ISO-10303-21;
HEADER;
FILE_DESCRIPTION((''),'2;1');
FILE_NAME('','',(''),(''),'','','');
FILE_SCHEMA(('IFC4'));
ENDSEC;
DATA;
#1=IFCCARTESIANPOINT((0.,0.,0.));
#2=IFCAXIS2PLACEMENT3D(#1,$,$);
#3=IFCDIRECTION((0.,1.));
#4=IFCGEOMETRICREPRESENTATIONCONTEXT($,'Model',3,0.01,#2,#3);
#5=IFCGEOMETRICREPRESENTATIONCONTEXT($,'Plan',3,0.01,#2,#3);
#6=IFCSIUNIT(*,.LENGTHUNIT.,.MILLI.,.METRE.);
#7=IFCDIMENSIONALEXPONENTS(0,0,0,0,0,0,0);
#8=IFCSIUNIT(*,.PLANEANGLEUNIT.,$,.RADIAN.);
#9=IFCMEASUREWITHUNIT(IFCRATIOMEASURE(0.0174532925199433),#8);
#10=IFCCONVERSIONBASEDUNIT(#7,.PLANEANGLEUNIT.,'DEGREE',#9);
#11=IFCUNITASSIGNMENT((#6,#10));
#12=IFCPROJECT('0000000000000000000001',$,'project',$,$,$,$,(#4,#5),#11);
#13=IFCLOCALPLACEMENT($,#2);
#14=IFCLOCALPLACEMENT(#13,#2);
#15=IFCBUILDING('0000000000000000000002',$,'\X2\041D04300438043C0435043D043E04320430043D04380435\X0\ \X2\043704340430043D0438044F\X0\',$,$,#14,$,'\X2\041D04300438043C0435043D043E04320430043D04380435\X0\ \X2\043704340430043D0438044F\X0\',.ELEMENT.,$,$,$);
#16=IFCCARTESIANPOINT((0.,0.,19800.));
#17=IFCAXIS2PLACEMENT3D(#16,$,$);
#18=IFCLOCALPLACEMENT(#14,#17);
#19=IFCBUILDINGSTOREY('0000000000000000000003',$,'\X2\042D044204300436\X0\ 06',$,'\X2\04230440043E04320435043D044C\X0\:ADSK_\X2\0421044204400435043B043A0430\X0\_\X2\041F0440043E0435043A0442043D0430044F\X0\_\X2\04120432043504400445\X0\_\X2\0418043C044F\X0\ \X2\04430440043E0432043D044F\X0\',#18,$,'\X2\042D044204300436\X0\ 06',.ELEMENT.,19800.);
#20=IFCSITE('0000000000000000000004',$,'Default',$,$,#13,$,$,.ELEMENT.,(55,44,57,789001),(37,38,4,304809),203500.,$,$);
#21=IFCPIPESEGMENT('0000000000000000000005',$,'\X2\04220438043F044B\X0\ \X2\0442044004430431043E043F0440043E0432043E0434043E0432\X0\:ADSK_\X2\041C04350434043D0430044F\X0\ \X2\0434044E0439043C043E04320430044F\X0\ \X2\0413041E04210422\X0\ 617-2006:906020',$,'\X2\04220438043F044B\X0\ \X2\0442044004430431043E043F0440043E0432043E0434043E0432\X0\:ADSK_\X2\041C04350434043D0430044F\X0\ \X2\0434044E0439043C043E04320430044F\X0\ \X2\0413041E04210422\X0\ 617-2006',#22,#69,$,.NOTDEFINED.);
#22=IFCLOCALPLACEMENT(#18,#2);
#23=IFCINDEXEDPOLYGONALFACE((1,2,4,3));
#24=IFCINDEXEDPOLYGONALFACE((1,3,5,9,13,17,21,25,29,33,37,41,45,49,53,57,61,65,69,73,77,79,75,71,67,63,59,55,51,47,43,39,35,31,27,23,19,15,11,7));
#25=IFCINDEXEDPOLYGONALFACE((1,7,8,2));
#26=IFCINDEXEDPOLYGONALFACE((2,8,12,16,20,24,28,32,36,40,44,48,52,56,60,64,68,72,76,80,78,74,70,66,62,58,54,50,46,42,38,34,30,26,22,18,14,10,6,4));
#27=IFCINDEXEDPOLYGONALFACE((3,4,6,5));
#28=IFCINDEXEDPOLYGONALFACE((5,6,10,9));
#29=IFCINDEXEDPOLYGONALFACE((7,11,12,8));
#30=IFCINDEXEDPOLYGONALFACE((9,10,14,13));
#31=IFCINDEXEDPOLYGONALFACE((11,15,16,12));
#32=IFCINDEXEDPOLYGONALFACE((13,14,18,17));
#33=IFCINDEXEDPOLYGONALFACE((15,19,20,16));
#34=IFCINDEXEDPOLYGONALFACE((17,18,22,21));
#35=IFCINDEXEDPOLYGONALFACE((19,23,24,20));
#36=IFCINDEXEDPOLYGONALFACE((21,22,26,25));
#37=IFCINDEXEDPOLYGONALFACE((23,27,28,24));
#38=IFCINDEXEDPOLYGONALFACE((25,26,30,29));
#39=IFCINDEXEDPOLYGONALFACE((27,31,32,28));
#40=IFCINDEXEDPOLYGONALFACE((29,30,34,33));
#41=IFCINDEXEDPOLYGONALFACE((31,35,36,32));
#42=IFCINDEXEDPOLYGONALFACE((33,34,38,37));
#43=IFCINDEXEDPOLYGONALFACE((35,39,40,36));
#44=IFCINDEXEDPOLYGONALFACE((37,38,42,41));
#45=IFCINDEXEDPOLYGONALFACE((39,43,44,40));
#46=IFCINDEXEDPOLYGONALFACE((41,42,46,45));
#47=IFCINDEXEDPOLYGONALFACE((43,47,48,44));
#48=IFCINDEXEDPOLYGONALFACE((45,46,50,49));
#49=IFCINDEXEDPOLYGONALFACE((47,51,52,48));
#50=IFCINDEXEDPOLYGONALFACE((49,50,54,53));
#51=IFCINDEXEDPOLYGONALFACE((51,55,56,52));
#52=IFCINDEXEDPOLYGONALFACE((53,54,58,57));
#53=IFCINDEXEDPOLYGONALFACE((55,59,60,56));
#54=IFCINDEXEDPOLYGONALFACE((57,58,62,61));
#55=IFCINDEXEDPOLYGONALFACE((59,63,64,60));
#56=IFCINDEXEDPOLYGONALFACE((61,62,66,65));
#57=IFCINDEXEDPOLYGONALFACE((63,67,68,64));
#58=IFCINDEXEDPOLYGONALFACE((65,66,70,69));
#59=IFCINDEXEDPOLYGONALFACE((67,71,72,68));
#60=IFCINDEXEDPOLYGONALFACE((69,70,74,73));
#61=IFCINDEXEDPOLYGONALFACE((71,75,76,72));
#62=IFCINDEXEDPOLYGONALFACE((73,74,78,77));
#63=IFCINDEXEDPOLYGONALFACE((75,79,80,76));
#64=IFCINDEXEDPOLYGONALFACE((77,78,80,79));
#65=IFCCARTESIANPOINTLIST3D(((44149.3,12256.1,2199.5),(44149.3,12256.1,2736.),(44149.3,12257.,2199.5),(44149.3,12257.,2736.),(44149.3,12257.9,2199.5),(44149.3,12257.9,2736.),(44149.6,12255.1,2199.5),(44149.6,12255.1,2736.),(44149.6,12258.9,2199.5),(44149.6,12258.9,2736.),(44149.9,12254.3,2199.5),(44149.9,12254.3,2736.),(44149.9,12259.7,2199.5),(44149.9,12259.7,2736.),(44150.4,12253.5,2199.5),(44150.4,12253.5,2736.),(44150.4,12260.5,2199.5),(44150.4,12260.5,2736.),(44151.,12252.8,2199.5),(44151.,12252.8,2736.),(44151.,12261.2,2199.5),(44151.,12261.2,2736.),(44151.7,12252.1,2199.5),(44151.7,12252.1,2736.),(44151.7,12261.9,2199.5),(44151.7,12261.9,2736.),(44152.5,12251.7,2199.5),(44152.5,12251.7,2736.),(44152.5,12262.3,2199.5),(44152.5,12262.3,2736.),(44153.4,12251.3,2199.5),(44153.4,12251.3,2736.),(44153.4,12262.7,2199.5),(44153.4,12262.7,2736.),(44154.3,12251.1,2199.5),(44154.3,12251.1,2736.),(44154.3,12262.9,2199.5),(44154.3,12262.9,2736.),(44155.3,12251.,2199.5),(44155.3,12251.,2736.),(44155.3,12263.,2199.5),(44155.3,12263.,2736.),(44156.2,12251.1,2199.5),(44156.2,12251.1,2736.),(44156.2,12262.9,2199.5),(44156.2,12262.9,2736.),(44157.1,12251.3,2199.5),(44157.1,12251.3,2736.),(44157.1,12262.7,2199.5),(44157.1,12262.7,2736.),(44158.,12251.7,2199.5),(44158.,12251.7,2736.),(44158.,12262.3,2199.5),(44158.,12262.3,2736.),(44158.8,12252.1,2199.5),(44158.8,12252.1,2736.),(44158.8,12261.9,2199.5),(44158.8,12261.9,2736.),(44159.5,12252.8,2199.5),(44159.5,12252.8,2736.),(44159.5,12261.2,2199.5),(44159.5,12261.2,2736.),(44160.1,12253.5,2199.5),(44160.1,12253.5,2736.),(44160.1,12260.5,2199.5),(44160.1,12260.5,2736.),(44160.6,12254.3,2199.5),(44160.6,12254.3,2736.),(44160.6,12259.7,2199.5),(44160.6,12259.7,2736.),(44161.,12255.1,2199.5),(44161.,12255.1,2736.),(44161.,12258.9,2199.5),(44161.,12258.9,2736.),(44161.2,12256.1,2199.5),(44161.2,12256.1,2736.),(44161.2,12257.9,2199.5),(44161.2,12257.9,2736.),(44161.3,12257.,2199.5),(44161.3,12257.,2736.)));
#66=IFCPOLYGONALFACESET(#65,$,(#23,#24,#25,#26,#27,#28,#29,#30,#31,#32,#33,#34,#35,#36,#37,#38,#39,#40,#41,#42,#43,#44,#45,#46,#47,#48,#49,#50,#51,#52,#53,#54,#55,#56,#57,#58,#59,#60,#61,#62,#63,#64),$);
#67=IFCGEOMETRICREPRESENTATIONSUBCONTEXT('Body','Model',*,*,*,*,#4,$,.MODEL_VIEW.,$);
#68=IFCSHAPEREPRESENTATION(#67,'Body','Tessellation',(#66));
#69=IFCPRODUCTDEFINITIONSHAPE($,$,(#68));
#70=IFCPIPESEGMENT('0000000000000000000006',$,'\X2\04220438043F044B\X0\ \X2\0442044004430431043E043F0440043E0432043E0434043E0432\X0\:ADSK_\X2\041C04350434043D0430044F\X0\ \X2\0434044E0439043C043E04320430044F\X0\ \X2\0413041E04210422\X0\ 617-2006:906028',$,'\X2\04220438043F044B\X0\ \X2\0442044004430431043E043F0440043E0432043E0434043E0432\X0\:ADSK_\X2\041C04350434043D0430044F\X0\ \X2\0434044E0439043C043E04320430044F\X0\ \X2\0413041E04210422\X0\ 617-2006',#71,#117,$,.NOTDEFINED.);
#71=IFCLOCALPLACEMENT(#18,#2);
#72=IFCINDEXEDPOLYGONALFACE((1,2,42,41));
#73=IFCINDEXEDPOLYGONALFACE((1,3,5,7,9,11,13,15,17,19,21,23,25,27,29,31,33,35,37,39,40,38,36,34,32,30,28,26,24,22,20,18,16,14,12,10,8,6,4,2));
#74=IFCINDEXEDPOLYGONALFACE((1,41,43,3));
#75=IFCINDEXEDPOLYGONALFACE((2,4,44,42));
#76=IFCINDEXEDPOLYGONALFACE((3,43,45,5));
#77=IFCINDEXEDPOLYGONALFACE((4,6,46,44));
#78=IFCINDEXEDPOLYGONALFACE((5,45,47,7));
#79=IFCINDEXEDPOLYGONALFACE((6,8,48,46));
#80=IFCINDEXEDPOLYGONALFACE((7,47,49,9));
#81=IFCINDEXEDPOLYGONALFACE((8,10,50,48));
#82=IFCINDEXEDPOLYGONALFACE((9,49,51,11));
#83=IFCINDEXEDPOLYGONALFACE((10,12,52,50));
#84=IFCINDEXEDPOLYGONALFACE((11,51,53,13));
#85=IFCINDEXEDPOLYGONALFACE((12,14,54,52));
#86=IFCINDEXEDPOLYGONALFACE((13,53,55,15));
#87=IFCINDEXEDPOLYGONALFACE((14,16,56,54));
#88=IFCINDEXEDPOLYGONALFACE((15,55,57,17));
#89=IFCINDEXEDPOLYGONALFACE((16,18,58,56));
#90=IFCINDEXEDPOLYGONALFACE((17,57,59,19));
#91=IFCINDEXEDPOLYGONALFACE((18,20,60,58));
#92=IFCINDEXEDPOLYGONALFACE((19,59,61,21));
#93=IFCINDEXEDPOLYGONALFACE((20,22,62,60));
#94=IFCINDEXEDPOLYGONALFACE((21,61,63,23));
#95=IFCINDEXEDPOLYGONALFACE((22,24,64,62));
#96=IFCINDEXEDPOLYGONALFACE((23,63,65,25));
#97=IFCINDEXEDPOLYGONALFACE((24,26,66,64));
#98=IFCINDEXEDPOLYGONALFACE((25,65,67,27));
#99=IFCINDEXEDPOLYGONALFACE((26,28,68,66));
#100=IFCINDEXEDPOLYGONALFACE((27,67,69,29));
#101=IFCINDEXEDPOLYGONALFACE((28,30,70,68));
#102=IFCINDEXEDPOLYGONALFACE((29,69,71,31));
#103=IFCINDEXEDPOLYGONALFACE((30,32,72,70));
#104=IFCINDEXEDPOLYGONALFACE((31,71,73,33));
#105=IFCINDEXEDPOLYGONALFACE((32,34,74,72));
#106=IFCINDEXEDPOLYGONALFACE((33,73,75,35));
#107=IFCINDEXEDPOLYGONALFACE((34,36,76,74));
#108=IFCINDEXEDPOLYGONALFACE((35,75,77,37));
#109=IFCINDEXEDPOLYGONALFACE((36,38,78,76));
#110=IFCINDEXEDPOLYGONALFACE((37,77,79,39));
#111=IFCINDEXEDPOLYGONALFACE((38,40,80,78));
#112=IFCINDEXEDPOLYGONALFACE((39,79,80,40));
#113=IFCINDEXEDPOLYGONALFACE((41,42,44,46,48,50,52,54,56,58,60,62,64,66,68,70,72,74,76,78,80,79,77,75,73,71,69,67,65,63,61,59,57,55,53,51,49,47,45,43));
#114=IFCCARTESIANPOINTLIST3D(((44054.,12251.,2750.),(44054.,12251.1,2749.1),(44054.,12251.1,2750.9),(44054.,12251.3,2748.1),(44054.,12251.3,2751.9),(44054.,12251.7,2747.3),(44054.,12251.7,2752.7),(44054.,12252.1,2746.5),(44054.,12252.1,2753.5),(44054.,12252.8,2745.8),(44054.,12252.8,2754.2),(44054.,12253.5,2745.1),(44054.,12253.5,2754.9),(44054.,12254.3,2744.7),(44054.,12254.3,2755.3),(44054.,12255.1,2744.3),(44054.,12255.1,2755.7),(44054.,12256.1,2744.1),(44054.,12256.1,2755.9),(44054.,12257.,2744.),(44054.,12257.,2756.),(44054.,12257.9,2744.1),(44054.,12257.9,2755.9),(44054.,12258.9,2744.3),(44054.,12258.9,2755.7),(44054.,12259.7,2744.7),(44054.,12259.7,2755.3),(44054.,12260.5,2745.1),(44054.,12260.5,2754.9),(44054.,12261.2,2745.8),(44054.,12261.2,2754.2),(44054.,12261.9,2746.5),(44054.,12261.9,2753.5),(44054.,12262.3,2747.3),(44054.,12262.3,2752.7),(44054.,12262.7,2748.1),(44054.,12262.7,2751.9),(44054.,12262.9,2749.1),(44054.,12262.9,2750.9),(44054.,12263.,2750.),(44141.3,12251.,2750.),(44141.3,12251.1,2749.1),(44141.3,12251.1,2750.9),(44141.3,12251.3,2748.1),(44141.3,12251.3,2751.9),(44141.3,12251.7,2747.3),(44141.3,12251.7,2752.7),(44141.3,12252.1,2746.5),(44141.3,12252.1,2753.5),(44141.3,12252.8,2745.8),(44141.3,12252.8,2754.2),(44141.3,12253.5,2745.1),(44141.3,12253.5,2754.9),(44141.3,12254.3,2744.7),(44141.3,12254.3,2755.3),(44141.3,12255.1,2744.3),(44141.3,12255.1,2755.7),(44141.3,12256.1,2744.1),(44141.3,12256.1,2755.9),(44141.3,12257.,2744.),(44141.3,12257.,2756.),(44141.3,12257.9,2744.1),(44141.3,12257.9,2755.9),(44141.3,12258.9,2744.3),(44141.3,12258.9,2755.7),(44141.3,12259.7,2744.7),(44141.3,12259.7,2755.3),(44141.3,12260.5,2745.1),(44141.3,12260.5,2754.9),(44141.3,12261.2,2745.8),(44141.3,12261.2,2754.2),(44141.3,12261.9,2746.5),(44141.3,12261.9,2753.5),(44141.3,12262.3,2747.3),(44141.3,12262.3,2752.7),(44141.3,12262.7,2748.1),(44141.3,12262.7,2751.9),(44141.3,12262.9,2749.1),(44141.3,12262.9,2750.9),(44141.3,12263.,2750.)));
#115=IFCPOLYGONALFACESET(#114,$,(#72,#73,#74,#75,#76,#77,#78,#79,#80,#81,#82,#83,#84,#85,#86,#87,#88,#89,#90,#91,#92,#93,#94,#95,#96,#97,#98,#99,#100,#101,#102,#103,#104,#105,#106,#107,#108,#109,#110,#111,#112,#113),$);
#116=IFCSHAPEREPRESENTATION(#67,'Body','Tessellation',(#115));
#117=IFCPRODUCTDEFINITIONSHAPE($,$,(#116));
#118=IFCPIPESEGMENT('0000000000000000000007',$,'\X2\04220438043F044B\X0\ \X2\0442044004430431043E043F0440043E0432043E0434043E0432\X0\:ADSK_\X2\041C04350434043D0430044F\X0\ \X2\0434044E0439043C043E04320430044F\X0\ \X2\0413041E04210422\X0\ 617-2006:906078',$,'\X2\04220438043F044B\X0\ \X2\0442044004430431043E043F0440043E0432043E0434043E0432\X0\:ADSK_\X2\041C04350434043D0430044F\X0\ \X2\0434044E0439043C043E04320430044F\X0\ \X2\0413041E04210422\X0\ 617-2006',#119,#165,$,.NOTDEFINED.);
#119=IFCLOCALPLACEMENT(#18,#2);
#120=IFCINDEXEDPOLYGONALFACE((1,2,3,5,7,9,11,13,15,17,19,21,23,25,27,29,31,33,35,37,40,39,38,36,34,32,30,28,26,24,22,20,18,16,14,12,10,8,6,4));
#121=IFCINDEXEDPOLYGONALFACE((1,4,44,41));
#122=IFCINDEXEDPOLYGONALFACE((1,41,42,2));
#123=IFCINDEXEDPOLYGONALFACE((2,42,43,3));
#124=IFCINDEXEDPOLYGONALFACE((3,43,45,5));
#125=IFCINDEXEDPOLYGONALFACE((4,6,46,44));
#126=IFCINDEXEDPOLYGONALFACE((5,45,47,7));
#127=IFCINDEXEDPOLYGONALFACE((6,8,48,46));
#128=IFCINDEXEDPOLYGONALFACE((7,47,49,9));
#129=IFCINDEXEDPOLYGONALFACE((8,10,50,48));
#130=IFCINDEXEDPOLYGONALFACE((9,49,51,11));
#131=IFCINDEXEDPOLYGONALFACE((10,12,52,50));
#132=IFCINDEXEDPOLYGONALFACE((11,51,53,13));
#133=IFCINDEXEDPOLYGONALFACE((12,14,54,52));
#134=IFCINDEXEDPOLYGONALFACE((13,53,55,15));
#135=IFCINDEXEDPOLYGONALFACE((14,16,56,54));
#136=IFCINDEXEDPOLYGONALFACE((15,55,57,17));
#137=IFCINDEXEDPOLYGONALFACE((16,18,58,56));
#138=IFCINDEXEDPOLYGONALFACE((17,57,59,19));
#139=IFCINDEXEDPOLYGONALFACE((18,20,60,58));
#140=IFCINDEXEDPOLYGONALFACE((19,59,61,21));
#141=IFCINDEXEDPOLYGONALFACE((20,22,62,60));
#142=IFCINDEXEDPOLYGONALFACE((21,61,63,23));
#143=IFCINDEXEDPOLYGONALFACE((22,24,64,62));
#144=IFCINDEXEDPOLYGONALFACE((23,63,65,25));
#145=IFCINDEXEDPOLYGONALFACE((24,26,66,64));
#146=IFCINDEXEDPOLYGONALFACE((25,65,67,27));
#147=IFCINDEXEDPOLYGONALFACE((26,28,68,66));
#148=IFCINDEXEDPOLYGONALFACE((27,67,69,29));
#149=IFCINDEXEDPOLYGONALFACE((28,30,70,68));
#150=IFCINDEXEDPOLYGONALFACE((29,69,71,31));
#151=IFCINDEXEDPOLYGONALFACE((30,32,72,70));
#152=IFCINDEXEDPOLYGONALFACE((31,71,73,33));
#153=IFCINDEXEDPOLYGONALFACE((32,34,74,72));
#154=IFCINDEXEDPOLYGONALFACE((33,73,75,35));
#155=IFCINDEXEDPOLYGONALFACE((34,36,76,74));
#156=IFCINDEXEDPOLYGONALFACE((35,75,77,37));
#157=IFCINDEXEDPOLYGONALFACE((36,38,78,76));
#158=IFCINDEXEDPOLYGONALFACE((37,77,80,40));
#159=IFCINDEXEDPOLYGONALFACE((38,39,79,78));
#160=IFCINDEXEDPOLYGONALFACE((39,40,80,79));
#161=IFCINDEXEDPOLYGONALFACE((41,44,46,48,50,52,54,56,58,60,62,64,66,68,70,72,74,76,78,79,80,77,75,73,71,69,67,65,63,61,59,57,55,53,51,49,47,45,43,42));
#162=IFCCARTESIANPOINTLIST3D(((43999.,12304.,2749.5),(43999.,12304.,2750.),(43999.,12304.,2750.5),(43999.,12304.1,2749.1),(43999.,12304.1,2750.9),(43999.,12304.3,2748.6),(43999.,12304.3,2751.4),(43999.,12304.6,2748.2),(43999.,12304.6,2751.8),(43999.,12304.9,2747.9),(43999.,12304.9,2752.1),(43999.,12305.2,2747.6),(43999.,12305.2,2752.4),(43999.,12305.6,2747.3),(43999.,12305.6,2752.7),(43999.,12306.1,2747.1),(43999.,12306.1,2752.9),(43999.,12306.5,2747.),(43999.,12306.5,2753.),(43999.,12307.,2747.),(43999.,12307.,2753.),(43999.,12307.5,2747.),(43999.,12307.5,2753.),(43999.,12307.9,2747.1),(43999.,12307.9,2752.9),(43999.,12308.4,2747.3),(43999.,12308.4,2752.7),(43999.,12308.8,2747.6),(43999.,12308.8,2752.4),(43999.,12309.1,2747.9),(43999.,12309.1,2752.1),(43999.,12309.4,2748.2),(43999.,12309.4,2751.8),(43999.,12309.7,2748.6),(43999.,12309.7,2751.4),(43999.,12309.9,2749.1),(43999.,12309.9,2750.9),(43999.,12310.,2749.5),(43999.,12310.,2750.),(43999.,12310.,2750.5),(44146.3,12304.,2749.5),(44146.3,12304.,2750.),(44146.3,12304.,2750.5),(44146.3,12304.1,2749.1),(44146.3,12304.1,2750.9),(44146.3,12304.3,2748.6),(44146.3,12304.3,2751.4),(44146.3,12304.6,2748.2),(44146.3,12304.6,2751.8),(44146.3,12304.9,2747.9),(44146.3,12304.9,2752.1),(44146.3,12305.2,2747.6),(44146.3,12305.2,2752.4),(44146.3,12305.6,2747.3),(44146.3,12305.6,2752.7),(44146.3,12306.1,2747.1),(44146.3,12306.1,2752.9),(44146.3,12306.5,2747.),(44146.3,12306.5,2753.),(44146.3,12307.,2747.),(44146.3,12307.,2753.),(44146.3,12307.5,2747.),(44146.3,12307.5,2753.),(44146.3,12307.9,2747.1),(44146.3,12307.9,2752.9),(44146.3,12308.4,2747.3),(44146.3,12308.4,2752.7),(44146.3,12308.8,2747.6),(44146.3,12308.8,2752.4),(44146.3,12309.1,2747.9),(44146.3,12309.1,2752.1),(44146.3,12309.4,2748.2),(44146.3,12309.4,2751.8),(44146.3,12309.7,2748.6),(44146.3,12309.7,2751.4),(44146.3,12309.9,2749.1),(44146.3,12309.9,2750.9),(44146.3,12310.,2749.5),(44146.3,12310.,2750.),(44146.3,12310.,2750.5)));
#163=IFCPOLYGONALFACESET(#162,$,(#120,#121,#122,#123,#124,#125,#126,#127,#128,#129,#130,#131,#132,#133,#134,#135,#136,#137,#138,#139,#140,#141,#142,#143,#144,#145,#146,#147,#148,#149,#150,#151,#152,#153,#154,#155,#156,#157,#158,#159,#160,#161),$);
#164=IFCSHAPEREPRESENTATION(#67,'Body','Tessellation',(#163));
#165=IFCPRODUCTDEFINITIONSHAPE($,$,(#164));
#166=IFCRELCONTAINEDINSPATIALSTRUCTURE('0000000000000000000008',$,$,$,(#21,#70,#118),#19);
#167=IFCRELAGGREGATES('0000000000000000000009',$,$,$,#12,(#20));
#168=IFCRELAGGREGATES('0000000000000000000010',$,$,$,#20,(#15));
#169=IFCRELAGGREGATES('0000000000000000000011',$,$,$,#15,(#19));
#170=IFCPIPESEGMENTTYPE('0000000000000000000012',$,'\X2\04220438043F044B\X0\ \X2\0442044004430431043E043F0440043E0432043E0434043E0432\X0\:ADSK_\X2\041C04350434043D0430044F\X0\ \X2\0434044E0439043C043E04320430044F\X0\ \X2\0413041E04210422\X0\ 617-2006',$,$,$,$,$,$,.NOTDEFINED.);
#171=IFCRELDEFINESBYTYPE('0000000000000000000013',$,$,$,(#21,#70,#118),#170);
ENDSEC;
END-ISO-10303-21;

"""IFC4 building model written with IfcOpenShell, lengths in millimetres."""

from ifc_helpers import new_model, entity, si_unit, converted_unit, direction, frame, origin, place, context, subcontext, project, spatial, indexed_curve, outline, extrude, type_object, element, save


model = new_model("IFC4")

# Units and contexts
model_context = context("Model", 3, precision=0.01, world=origin(), true_north=direction((0.0, 1.0)))
plan_context = context("Plan", 3, precision=0.01, world=origin(), true_north=direction((0.0, 1.0)))
body_context = subcontext(model_context, "Body", "Model", "MODEL_VIEW")
ifc_project = project(units=[si_unit("LENGTHUNIT", "METRE", prefix="MILLI"), converted_unit("PLANEANGLEUNIT", "DEGREE", entity("IfcRatioMeasure", 0.0174532925199433), si_unit("PLANEANGLEUNIT", "RADIAN"), dimensions=[0, 0, 0, 0, 0, 0, 0])], contexts=[model_context, plan_context])

# Site, building, storey
site_placement = place(None, origin())
site = spatial("IfcSite", under=ifc_project, at=site_placement, Name="Default", CompositionType="ELEMENT", RefLatitude=(55, 44, 57, 789001), RefLongitude=(37, 38, 4, 304809), RefElevation=203500.0)
building_placement = place(site_placement, origin())
building = spatial("IfcBuilding", under=site, at=building_placement, Name="Наименование здания", LongName="Наименование здания", CompositionType="ELEMENT")
storey_placement = place(building_placement, frame((0.0, 0.0, 19800.0)))
storey = spatial("IfcBuildingStorey", under=building, at=storey_placement, Name="Этаж 06", ObjectType="Уровень:ADSK_Стрелка_Проектная_Вверх_Имя уровня", LongName="Этаж 06", CompositionType="ELEMENT", Elevation=19800.0)

# Pipe segments
pipe_segment_type = type_object("IfcPipeSegmentType", Name="Типы трубопроводов:ADSK_Медная дюймовая ГОСТ 617-2006", PredefinedType="NOTDEFINED")
placement = place(storey_placement, origin())
element("IfcPipeSegment", 1, at=placement, inside=storey, type_object=pipe_segment_type, Name="Типы трубопроводов:ADSK_Медная дюймовая ГОСТ 617-2006:906020", ObjectType="Типы трубопроводов:ADSK_Медная дюймовая ГОСТ 617-2006", PredefinedType="NOTDEFINED", context=body_context, shape_type="SweptSolid", body=[
    extrude(outline(indexed_curve([(6.0, 0.0), (5.9, 0.9), (5.7, 1.9), (5.3, 2.7), (4.9, 3.5), (4.2, 4.2), (3.5, 4.9), (2.7, 5.3), (1.9, 5.7), (0.9, 5.9), (0.0, 6.0), (-0.9, 5.9), (-1.9, 5.7), (-2.7, 5.3), (-3.5, 4.9), (-4.2, 4.2), (-4.9, 3.5), (-5.3, 2.7), (-5.7, 1.9), (-5.9, 0.9), (-6.0, 0.0), (-5.9, -0.9), (-5.7, -1.9), (-5.3, -2.7), (-4.9, -3.5), (-4.2, -4.2), (-3.5, -4.9), (-2.7, -5.3), (-1.9, -5.7), (-0.9, -5.9), (0.0, -6.0), (0.9, -5.9), (1.9, -5.7), (2.7, -5.3), (3.5, -4.9), (4.2, -4.2), (4.9, -3.5), (5.3, -2.7), (5.7, -1.9), (5.9, -0.9), (6.0, 0.0)], self_intersect=False)), frame((44155.3, 12257.0, 2199.5), z_axis=(0.0, 0.0, 1.0), x_axis=(-1.0, 0.0, 0.0)), (0.0, 0.0, 1.0), 536.5),
])
element("IfcPipeSegment", 2, at=placement, inside=storey, type_object=pipe_segment_type, Name="Типы трубопроводов:ADSK_Медная дюймовая ГОСТ 617-2006:906028", ObjectType="Типы трубопроводов:ADSK_Медная дюймовая ГОСТ 617-2006", PredefinedType="NOTDEFINED", context=body_context, shape_type="SweptSolid", body=[
    extrude(outline(indexed_curve([(6.0, 0.0), (5.9, 0.9), (5.7, 1.9), (5.3, 2.7), (4.9, 3.5), (4.2, 4.2), (3.5, 4.9), (2.7, 5.3), (1.9, 5.7), (0.9, 5.9), (0.0, 6.0), (-0.9, 5.9), (-1.9, 5.7), (-2.7, 5.3), (-3.5, 4.9), (-4.2, 4.2), (-4.9, 3.5), (-5.3, 2.7), (-5.7, 1.9), (-5.9, 0.9), (-6.0, 0.0), (-5.9, -0.9), (-5.7, -1.9), (-5.3, -2.7), (-4.9, -3.5), (-4.2, -4.2), (-3.5, -4.9), (-2.7, -5.3), (-1.9, -5.7), (-0.9, -5.9), (0.0, -6.0), (0.9, -5.9), (1.9, -5.7), (2.7, -5.3), (3.5, -4.9), (4.2, -4.2), (4.9, -3.5), (5.3, -2.7), (5.7, -1.9), (5.9, -0.9), (6.0, 0.0)], self_intersect=False)), frame((44054.0, 12257.0, 2750.0), z_axis=(1.0, 0.0, 0.0), x_axis=(0.0, 1.0, 0.0)), (0.0, 0.0, 1.0), 87.3),
])
element("IfcPipeSegment", 3, at=placement, inside=storey, type_object=pipe_segment_type, Name="Типы трубопроводов:ADSK_Медная дюймовая ГОСТ 617-2006:906078", ObjectType="Типы трубопроводов:ADSK_Медная дюймовая ГОСТ 617-2006", PredefinedType="NOTDEFINED", context=body_context, shape_type="SweptSolid", body=[
    extrude(outline(indexed_curve([(3.0, 0.0), (3.0, 0.5), (2.9, 0.9), (2.7, 1.4), (2.4, 1.8), (2.1, 2.1), (1.8, 2.4), (1.4, 2.7), (0.9, 2.9), (0.5, 3.0), (0.0, 3.0), (-0.5, 3.0), (-0.9, 2.9), (-1.4, 2.7), (-1.8, 2.4), (-2.1, 2.1), (-2.4, 1.8), (-2.7, 1.4), (-2.9, 0.9), (-3.0, 0.5), (-3.0, 0.0), (-3.0, -0.5), (-2.9, -0.9), (-2.7, -1.4), (-2.4, -1.8), (-2.1, -2.1), (-1.8, -2.4), (-1.4, -2.7), (-0.9, -2.9), (-0.5, -3.0), (0.0, -3.0), (0.5, -3.0), (0.9, -2.9), (1.4, -2.7), (1.8, -2.4), (2.1, -2.1), (2.4, -1.8), (2.7, -1.4), (2.9, -0.9), (3.0, -0.5), (3.0, 0.0)], self_intersect=False)), frame((43999.0, 12307.0, 2750.0), z_axis=(1.0, 0.0, 0.0), x_axis=(0.0, -1.0, 0.0)), (0.0, 0.0, 1.0), 147.3),
])

save(model, "model.ifc")
